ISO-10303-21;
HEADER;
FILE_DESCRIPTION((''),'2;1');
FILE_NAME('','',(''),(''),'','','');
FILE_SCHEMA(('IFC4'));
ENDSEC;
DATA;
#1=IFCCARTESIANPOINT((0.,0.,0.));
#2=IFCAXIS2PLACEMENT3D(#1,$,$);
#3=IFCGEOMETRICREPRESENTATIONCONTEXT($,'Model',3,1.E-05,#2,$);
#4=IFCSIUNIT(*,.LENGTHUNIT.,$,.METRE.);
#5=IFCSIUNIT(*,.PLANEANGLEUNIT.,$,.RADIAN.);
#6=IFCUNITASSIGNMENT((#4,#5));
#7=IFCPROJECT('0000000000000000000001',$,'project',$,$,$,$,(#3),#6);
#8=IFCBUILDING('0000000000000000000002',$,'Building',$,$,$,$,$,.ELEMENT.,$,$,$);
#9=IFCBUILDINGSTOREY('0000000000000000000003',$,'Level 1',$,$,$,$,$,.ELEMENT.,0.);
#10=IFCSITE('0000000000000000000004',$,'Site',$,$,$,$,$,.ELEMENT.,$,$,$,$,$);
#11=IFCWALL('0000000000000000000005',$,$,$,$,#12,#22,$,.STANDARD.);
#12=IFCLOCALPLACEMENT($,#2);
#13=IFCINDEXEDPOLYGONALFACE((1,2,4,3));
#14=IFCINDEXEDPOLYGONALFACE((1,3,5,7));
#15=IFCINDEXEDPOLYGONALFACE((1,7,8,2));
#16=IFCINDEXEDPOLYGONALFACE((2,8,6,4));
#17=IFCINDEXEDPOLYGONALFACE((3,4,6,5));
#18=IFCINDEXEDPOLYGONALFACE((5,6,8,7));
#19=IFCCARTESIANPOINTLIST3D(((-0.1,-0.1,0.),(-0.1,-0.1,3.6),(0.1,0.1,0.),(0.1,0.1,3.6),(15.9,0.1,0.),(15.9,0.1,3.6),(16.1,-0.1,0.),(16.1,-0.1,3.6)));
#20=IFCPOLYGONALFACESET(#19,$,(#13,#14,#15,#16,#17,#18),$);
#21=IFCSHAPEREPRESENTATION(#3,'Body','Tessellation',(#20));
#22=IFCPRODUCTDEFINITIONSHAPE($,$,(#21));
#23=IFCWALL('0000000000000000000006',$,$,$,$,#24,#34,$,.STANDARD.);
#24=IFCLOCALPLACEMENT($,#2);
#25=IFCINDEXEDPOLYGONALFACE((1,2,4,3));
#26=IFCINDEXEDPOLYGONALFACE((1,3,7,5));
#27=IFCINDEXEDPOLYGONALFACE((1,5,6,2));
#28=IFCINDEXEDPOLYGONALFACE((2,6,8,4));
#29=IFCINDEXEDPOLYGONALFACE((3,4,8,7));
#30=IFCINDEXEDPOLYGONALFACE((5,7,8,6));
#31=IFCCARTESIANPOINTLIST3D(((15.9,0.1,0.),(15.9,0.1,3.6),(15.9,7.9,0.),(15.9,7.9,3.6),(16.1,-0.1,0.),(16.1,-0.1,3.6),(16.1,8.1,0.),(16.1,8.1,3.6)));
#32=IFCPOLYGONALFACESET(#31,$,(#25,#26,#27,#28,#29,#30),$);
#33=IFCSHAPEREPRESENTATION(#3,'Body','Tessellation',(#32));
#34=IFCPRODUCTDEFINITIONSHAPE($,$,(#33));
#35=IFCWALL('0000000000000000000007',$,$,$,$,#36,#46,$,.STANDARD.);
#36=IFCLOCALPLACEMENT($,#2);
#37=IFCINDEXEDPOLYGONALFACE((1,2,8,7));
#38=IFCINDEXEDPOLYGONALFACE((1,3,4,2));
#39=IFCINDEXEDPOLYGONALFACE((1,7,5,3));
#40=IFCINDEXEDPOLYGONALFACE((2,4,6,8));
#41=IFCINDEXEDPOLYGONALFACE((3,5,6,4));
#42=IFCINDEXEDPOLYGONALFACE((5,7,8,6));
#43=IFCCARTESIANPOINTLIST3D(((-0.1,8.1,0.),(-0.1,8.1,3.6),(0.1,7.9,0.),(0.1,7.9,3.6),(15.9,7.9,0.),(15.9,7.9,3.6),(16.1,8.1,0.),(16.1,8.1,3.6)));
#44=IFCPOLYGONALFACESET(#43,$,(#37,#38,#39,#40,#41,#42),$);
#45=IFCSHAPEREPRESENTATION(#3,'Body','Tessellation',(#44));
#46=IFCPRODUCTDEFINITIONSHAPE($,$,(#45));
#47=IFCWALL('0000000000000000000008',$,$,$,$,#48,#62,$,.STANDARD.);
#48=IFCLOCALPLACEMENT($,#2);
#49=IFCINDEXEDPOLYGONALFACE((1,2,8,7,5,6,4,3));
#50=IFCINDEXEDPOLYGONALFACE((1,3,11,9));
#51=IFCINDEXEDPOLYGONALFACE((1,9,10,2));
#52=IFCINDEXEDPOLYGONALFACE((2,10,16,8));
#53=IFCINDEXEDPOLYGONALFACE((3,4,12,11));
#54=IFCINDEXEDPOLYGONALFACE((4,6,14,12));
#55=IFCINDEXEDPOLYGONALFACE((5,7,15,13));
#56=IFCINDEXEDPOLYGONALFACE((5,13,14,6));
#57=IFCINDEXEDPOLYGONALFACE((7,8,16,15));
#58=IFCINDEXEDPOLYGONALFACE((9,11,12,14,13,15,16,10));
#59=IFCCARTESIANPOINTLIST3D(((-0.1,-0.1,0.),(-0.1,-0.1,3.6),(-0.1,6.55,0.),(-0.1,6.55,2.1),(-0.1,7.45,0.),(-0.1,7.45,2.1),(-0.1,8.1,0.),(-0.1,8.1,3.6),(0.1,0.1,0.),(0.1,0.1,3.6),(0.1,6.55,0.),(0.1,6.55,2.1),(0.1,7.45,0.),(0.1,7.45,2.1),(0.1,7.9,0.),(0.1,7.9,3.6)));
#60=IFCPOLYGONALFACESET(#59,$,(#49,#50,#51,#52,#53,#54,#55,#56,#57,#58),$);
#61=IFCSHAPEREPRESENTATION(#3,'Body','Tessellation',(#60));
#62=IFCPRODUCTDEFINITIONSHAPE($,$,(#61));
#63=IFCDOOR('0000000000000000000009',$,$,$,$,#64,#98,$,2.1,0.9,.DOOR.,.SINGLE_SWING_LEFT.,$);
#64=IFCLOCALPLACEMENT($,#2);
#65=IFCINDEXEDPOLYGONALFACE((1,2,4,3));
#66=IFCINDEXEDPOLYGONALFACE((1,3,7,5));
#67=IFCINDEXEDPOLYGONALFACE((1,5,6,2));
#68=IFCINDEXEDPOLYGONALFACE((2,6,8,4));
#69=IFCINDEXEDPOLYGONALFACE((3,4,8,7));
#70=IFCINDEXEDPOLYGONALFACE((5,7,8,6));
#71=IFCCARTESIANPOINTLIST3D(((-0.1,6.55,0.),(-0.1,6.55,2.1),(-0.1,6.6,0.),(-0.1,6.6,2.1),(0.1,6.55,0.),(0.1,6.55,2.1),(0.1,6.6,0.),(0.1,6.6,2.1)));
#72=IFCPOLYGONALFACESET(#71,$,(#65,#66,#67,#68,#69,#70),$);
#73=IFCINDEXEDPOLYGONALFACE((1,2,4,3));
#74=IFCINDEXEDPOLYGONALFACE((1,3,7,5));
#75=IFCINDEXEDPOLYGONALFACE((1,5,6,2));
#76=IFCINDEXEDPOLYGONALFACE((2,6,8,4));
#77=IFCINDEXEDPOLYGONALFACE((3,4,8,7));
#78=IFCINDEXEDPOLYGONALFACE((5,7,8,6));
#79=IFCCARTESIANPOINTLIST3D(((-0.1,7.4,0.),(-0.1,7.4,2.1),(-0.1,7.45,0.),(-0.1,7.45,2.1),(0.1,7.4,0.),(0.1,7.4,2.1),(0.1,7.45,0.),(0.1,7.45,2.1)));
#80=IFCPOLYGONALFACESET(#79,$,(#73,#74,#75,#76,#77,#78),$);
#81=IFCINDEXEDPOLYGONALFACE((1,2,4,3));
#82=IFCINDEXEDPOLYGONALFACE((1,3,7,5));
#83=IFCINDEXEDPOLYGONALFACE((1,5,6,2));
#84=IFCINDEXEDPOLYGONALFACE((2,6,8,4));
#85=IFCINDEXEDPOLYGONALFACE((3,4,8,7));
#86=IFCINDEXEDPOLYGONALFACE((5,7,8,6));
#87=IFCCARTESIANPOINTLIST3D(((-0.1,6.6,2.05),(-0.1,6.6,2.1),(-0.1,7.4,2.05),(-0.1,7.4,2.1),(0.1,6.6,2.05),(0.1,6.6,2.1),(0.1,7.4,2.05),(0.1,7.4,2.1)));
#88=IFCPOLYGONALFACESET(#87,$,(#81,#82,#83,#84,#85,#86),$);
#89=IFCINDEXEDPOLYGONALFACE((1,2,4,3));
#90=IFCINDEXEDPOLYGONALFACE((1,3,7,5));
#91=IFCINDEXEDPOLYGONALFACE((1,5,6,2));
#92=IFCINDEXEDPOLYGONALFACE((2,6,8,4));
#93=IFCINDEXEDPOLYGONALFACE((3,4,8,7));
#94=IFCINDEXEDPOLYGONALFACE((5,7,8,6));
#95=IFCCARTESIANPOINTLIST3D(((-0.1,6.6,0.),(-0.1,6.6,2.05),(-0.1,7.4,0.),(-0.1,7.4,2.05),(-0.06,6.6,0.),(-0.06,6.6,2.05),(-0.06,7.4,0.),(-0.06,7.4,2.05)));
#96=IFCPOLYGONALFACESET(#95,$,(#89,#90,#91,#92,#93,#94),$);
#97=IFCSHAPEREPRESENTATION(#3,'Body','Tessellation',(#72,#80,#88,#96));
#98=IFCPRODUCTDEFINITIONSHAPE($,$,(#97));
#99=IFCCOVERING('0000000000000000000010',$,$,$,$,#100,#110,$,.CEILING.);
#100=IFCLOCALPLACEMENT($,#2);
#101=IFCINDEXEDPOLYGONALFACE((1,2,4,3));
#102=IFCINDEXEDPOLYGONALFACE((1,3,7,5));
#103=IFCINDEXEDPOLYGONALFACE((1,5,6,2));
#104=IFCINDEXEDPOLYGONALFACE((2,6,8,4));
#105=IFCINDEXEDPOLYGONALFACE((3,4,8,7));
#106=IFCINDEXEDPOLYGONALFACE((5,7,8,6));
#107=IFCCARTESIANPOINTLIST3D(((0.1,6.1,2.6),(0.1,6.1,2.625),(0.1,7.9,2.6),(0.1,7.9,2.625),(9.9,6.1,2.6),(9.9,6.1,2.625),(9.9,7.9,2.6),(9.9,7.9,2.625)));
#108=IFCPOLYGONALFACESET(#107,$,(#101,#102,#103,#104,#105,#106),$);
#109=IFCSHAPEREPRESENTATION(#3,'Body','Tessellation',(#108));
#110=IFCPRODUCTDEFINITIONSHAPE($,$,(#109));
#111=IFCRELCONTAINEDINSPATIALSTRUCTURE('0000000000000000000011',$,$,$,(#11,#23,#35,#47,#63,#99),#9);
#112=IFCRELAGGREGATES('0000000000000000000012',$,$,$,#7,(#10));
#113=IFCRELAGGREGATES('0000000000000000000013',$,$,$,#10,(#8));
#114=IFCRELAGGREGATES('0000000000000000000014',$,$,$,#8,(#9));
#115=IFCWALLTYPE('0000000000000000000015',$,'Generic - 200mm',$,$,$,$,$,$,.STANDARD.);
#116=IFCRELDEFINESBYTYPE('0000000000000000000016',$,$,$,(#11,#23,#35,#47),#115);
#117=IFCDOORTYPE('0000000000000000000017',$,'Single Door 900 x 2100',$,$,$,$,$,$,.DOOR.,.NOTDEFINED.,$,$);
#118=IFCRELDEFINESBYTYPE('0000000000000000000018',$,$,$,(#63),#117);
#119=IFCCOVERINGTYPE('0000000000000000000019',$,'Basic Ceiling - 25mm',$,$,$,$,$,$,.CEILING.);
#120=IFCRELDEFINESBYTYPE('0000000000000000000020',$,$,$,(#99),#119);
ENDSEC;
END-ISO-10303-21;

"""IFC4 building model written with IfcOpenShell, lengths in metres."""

from ifc_helpers import new_model, si_unit, frame, frame_2d, origin, origin_with_axes, origin_2d, place, context, project, spatial, polyline, rectangle, outline, extrude, type_object, element, fill, save


model = new_model("IFC4")

# Units and contexts
model_context = context("Model", 3, precision=1e-05, world=origin())
ifc_project = project(units=[si_unit("LENGTHUNIT", "METRE"), si_unit("PLANEANGLEUNIT", "RADIAN")], contexts=[model_context])

# Site, building, storey
site = spatial("IfcSite", under=ifc_project, Name="Site", CompositionType="ELEMENT")
building = spatial("IfcBuilding", under=site, Name="Building", CompositionType="ELEMENT")
storey = spatial("IfcBuildingStorey", under=building, Name="Level 1", CompositionType="ELEMENT", Elevation=0.0)

# Walls
wall_type = type_object("IfcWallType", Name="Generic - 200mm", PredefinedType="STANDARD")
wall_1_placement = place(None, frame((16.0, 0.0, 0.0), z_axis=(0.0, 0.0, 1.0), x_axis=(-1.0, 0.0, 0.0)))
element("IfcWall", 1, at=wall_1_placement, inside=storey, type_object=wall_type, PredefinedType="STANDARD", context=model_context, shape_type="SweptSolid", body=[
    extrude(outline(polyline([(0.1, -0.1), (15.9, -0.1), (16.1, 0.1), (-0.1, 0.1), (0.1, -0.1)])), origin(), (0.0, 0.0, 1.0), 3.6),
])
wall_2_placement = place(None, frame((16.0, 8.0, 0.0), z_axis=(0.0, 0.0, 1.0), x_axis=(0.0, -1.0, 0.0)))
element("IfcWall", 2, at=wall_2_placement, inside=storey, type_object=wall_type, PredefinedType="STANDARD", context=model_context, shape_type="SweptSolid", body=[
    extrude(outline(polyline([(0.1, -0.1), (7.9, -0.1), (8.1, 0.1), (-0.1, 0.1), (0.1, -0.1)])), origin(), (0.0, 0.0, 1.0), 3.6),
])
wall_3_placement = place(None, frame((0.0, 8.0, 0.0), z_axis=(0.0, 0.0, 1.0), x_axis=(1.0, 0.0, 0.0)))
element("IfcWall", 3, at=wall_3_placement, inside=storey, type_object=wall_type, PredefinedType="STANDARD", context=model_context, shape_type="SweptSolid", body=[
    extrude(outline(polyline([(0.1, -0.1), (15.9, -0.1), (16.1, 0.1), (-0.1, 0.1), (0.1, -0.1)])), origin(), (0.0, 0.0, 1.0), 3.6),
])

# Wall, opening, door
wall_4_placement = place(None, frame((0.0, 0.0, 0.0), z_axis=(0.0, 0.0, 1.0), x_axis=(0.0, 1.0, 0.0)))
wall_4 = element("IfcWall", 4, at=wall_4_placement, inside=storey, type_object=wall_type, PredefinedType="STANDARD", context=model_context, shape_type="SweptSolid", body=[
    extrude(outline(polyline([(0.1, -0.1), (7.9, -0.1), (8.1, 0.1), (-0.1, 0.1), (0.1, -0.1)])), origin(), (0.0, 0.0, 1.0), 3.6),
])
opening_placement = place(wall_4_placement, frame((7.0, 0.0, 0.0), z_axis=(0.0, 0.0, 1.0), x_axis=(1.0, 0.0, 0.0)))
opening = element("IfcOpeningElement", 5, at=opening_placement, cuts=wall_4, PredefinedType="OPENING", context=model_context, shape_type="SweptSolid", body=[
    extrude(rectangle(XDim=0.9, YDim=0.202, at=origin_2d()), origin(), (0.0, 0.0, 1.0), 2.1),
])
door_type = type_object("IfcDoorType", Name="Single Door 900 x 2100", OperationType="NOTDEFINED", PredefinedType="DOOR")
door_placement = place(opening_placement, origin_with_axes())
door = element("IfcDoor", 6, at=door_placement, inside=storey, type_object=door_type, OperationType="SINGLE_SWING_LEFT", OverallHeight=2.1, OverallWidth=0.9, PredefinedType="DOOR", context=model_context, shape_type="SweptSolid", body=[
    extrude(rectangle(XDim=0.05, YDim=0.2, at=frame_2d((-0.425, 0.0))), origin(), (0.0, 0.0, 1.0), 2.1),
    extrude(rectangle(XDim=0.05, YDim=0.2, at=frame_2d((0.425, 0.0))), origin(), (0.0, 0.0, 1.0), 2.1),
    extrude(rectangle(XDim=0.8, YDim=0.2, at=origin_2d()), frame((0.0, 0.0, 2.05)), (0.0, 0.0, 1.0), 0.05),
    extrude(rectangle(XDim=0.8, YDim=0.04, at=frame_2d((0.0, 0.08))), origin(), (0.0, 0.0, 1.0), 2.05),
])
fill(opening, door)

# Covering
covering_type = type_object("IfcCoveringType", Name="Basic Ceiling - 25mm", PredefinedType="CEILING")
covering_placement = place(None, frame((0.0, 0.0, 2.625)))
element("IfcCovering", 7, at=covering_placement, inside=storey, type_object=covering_type, PredefinedType="CEILING", context=model_context, shape_type="SweptSolid", body=[
    extrude(outline(polyline([(9.9, 7.9), (0.1, 7.9), (0.1, 6.1), (9.9, 6.1), (9.9, 7.9)])), origin(), (0.0, 0.0, -1.0), 0.025),
])

save(model, "model.ifc")
